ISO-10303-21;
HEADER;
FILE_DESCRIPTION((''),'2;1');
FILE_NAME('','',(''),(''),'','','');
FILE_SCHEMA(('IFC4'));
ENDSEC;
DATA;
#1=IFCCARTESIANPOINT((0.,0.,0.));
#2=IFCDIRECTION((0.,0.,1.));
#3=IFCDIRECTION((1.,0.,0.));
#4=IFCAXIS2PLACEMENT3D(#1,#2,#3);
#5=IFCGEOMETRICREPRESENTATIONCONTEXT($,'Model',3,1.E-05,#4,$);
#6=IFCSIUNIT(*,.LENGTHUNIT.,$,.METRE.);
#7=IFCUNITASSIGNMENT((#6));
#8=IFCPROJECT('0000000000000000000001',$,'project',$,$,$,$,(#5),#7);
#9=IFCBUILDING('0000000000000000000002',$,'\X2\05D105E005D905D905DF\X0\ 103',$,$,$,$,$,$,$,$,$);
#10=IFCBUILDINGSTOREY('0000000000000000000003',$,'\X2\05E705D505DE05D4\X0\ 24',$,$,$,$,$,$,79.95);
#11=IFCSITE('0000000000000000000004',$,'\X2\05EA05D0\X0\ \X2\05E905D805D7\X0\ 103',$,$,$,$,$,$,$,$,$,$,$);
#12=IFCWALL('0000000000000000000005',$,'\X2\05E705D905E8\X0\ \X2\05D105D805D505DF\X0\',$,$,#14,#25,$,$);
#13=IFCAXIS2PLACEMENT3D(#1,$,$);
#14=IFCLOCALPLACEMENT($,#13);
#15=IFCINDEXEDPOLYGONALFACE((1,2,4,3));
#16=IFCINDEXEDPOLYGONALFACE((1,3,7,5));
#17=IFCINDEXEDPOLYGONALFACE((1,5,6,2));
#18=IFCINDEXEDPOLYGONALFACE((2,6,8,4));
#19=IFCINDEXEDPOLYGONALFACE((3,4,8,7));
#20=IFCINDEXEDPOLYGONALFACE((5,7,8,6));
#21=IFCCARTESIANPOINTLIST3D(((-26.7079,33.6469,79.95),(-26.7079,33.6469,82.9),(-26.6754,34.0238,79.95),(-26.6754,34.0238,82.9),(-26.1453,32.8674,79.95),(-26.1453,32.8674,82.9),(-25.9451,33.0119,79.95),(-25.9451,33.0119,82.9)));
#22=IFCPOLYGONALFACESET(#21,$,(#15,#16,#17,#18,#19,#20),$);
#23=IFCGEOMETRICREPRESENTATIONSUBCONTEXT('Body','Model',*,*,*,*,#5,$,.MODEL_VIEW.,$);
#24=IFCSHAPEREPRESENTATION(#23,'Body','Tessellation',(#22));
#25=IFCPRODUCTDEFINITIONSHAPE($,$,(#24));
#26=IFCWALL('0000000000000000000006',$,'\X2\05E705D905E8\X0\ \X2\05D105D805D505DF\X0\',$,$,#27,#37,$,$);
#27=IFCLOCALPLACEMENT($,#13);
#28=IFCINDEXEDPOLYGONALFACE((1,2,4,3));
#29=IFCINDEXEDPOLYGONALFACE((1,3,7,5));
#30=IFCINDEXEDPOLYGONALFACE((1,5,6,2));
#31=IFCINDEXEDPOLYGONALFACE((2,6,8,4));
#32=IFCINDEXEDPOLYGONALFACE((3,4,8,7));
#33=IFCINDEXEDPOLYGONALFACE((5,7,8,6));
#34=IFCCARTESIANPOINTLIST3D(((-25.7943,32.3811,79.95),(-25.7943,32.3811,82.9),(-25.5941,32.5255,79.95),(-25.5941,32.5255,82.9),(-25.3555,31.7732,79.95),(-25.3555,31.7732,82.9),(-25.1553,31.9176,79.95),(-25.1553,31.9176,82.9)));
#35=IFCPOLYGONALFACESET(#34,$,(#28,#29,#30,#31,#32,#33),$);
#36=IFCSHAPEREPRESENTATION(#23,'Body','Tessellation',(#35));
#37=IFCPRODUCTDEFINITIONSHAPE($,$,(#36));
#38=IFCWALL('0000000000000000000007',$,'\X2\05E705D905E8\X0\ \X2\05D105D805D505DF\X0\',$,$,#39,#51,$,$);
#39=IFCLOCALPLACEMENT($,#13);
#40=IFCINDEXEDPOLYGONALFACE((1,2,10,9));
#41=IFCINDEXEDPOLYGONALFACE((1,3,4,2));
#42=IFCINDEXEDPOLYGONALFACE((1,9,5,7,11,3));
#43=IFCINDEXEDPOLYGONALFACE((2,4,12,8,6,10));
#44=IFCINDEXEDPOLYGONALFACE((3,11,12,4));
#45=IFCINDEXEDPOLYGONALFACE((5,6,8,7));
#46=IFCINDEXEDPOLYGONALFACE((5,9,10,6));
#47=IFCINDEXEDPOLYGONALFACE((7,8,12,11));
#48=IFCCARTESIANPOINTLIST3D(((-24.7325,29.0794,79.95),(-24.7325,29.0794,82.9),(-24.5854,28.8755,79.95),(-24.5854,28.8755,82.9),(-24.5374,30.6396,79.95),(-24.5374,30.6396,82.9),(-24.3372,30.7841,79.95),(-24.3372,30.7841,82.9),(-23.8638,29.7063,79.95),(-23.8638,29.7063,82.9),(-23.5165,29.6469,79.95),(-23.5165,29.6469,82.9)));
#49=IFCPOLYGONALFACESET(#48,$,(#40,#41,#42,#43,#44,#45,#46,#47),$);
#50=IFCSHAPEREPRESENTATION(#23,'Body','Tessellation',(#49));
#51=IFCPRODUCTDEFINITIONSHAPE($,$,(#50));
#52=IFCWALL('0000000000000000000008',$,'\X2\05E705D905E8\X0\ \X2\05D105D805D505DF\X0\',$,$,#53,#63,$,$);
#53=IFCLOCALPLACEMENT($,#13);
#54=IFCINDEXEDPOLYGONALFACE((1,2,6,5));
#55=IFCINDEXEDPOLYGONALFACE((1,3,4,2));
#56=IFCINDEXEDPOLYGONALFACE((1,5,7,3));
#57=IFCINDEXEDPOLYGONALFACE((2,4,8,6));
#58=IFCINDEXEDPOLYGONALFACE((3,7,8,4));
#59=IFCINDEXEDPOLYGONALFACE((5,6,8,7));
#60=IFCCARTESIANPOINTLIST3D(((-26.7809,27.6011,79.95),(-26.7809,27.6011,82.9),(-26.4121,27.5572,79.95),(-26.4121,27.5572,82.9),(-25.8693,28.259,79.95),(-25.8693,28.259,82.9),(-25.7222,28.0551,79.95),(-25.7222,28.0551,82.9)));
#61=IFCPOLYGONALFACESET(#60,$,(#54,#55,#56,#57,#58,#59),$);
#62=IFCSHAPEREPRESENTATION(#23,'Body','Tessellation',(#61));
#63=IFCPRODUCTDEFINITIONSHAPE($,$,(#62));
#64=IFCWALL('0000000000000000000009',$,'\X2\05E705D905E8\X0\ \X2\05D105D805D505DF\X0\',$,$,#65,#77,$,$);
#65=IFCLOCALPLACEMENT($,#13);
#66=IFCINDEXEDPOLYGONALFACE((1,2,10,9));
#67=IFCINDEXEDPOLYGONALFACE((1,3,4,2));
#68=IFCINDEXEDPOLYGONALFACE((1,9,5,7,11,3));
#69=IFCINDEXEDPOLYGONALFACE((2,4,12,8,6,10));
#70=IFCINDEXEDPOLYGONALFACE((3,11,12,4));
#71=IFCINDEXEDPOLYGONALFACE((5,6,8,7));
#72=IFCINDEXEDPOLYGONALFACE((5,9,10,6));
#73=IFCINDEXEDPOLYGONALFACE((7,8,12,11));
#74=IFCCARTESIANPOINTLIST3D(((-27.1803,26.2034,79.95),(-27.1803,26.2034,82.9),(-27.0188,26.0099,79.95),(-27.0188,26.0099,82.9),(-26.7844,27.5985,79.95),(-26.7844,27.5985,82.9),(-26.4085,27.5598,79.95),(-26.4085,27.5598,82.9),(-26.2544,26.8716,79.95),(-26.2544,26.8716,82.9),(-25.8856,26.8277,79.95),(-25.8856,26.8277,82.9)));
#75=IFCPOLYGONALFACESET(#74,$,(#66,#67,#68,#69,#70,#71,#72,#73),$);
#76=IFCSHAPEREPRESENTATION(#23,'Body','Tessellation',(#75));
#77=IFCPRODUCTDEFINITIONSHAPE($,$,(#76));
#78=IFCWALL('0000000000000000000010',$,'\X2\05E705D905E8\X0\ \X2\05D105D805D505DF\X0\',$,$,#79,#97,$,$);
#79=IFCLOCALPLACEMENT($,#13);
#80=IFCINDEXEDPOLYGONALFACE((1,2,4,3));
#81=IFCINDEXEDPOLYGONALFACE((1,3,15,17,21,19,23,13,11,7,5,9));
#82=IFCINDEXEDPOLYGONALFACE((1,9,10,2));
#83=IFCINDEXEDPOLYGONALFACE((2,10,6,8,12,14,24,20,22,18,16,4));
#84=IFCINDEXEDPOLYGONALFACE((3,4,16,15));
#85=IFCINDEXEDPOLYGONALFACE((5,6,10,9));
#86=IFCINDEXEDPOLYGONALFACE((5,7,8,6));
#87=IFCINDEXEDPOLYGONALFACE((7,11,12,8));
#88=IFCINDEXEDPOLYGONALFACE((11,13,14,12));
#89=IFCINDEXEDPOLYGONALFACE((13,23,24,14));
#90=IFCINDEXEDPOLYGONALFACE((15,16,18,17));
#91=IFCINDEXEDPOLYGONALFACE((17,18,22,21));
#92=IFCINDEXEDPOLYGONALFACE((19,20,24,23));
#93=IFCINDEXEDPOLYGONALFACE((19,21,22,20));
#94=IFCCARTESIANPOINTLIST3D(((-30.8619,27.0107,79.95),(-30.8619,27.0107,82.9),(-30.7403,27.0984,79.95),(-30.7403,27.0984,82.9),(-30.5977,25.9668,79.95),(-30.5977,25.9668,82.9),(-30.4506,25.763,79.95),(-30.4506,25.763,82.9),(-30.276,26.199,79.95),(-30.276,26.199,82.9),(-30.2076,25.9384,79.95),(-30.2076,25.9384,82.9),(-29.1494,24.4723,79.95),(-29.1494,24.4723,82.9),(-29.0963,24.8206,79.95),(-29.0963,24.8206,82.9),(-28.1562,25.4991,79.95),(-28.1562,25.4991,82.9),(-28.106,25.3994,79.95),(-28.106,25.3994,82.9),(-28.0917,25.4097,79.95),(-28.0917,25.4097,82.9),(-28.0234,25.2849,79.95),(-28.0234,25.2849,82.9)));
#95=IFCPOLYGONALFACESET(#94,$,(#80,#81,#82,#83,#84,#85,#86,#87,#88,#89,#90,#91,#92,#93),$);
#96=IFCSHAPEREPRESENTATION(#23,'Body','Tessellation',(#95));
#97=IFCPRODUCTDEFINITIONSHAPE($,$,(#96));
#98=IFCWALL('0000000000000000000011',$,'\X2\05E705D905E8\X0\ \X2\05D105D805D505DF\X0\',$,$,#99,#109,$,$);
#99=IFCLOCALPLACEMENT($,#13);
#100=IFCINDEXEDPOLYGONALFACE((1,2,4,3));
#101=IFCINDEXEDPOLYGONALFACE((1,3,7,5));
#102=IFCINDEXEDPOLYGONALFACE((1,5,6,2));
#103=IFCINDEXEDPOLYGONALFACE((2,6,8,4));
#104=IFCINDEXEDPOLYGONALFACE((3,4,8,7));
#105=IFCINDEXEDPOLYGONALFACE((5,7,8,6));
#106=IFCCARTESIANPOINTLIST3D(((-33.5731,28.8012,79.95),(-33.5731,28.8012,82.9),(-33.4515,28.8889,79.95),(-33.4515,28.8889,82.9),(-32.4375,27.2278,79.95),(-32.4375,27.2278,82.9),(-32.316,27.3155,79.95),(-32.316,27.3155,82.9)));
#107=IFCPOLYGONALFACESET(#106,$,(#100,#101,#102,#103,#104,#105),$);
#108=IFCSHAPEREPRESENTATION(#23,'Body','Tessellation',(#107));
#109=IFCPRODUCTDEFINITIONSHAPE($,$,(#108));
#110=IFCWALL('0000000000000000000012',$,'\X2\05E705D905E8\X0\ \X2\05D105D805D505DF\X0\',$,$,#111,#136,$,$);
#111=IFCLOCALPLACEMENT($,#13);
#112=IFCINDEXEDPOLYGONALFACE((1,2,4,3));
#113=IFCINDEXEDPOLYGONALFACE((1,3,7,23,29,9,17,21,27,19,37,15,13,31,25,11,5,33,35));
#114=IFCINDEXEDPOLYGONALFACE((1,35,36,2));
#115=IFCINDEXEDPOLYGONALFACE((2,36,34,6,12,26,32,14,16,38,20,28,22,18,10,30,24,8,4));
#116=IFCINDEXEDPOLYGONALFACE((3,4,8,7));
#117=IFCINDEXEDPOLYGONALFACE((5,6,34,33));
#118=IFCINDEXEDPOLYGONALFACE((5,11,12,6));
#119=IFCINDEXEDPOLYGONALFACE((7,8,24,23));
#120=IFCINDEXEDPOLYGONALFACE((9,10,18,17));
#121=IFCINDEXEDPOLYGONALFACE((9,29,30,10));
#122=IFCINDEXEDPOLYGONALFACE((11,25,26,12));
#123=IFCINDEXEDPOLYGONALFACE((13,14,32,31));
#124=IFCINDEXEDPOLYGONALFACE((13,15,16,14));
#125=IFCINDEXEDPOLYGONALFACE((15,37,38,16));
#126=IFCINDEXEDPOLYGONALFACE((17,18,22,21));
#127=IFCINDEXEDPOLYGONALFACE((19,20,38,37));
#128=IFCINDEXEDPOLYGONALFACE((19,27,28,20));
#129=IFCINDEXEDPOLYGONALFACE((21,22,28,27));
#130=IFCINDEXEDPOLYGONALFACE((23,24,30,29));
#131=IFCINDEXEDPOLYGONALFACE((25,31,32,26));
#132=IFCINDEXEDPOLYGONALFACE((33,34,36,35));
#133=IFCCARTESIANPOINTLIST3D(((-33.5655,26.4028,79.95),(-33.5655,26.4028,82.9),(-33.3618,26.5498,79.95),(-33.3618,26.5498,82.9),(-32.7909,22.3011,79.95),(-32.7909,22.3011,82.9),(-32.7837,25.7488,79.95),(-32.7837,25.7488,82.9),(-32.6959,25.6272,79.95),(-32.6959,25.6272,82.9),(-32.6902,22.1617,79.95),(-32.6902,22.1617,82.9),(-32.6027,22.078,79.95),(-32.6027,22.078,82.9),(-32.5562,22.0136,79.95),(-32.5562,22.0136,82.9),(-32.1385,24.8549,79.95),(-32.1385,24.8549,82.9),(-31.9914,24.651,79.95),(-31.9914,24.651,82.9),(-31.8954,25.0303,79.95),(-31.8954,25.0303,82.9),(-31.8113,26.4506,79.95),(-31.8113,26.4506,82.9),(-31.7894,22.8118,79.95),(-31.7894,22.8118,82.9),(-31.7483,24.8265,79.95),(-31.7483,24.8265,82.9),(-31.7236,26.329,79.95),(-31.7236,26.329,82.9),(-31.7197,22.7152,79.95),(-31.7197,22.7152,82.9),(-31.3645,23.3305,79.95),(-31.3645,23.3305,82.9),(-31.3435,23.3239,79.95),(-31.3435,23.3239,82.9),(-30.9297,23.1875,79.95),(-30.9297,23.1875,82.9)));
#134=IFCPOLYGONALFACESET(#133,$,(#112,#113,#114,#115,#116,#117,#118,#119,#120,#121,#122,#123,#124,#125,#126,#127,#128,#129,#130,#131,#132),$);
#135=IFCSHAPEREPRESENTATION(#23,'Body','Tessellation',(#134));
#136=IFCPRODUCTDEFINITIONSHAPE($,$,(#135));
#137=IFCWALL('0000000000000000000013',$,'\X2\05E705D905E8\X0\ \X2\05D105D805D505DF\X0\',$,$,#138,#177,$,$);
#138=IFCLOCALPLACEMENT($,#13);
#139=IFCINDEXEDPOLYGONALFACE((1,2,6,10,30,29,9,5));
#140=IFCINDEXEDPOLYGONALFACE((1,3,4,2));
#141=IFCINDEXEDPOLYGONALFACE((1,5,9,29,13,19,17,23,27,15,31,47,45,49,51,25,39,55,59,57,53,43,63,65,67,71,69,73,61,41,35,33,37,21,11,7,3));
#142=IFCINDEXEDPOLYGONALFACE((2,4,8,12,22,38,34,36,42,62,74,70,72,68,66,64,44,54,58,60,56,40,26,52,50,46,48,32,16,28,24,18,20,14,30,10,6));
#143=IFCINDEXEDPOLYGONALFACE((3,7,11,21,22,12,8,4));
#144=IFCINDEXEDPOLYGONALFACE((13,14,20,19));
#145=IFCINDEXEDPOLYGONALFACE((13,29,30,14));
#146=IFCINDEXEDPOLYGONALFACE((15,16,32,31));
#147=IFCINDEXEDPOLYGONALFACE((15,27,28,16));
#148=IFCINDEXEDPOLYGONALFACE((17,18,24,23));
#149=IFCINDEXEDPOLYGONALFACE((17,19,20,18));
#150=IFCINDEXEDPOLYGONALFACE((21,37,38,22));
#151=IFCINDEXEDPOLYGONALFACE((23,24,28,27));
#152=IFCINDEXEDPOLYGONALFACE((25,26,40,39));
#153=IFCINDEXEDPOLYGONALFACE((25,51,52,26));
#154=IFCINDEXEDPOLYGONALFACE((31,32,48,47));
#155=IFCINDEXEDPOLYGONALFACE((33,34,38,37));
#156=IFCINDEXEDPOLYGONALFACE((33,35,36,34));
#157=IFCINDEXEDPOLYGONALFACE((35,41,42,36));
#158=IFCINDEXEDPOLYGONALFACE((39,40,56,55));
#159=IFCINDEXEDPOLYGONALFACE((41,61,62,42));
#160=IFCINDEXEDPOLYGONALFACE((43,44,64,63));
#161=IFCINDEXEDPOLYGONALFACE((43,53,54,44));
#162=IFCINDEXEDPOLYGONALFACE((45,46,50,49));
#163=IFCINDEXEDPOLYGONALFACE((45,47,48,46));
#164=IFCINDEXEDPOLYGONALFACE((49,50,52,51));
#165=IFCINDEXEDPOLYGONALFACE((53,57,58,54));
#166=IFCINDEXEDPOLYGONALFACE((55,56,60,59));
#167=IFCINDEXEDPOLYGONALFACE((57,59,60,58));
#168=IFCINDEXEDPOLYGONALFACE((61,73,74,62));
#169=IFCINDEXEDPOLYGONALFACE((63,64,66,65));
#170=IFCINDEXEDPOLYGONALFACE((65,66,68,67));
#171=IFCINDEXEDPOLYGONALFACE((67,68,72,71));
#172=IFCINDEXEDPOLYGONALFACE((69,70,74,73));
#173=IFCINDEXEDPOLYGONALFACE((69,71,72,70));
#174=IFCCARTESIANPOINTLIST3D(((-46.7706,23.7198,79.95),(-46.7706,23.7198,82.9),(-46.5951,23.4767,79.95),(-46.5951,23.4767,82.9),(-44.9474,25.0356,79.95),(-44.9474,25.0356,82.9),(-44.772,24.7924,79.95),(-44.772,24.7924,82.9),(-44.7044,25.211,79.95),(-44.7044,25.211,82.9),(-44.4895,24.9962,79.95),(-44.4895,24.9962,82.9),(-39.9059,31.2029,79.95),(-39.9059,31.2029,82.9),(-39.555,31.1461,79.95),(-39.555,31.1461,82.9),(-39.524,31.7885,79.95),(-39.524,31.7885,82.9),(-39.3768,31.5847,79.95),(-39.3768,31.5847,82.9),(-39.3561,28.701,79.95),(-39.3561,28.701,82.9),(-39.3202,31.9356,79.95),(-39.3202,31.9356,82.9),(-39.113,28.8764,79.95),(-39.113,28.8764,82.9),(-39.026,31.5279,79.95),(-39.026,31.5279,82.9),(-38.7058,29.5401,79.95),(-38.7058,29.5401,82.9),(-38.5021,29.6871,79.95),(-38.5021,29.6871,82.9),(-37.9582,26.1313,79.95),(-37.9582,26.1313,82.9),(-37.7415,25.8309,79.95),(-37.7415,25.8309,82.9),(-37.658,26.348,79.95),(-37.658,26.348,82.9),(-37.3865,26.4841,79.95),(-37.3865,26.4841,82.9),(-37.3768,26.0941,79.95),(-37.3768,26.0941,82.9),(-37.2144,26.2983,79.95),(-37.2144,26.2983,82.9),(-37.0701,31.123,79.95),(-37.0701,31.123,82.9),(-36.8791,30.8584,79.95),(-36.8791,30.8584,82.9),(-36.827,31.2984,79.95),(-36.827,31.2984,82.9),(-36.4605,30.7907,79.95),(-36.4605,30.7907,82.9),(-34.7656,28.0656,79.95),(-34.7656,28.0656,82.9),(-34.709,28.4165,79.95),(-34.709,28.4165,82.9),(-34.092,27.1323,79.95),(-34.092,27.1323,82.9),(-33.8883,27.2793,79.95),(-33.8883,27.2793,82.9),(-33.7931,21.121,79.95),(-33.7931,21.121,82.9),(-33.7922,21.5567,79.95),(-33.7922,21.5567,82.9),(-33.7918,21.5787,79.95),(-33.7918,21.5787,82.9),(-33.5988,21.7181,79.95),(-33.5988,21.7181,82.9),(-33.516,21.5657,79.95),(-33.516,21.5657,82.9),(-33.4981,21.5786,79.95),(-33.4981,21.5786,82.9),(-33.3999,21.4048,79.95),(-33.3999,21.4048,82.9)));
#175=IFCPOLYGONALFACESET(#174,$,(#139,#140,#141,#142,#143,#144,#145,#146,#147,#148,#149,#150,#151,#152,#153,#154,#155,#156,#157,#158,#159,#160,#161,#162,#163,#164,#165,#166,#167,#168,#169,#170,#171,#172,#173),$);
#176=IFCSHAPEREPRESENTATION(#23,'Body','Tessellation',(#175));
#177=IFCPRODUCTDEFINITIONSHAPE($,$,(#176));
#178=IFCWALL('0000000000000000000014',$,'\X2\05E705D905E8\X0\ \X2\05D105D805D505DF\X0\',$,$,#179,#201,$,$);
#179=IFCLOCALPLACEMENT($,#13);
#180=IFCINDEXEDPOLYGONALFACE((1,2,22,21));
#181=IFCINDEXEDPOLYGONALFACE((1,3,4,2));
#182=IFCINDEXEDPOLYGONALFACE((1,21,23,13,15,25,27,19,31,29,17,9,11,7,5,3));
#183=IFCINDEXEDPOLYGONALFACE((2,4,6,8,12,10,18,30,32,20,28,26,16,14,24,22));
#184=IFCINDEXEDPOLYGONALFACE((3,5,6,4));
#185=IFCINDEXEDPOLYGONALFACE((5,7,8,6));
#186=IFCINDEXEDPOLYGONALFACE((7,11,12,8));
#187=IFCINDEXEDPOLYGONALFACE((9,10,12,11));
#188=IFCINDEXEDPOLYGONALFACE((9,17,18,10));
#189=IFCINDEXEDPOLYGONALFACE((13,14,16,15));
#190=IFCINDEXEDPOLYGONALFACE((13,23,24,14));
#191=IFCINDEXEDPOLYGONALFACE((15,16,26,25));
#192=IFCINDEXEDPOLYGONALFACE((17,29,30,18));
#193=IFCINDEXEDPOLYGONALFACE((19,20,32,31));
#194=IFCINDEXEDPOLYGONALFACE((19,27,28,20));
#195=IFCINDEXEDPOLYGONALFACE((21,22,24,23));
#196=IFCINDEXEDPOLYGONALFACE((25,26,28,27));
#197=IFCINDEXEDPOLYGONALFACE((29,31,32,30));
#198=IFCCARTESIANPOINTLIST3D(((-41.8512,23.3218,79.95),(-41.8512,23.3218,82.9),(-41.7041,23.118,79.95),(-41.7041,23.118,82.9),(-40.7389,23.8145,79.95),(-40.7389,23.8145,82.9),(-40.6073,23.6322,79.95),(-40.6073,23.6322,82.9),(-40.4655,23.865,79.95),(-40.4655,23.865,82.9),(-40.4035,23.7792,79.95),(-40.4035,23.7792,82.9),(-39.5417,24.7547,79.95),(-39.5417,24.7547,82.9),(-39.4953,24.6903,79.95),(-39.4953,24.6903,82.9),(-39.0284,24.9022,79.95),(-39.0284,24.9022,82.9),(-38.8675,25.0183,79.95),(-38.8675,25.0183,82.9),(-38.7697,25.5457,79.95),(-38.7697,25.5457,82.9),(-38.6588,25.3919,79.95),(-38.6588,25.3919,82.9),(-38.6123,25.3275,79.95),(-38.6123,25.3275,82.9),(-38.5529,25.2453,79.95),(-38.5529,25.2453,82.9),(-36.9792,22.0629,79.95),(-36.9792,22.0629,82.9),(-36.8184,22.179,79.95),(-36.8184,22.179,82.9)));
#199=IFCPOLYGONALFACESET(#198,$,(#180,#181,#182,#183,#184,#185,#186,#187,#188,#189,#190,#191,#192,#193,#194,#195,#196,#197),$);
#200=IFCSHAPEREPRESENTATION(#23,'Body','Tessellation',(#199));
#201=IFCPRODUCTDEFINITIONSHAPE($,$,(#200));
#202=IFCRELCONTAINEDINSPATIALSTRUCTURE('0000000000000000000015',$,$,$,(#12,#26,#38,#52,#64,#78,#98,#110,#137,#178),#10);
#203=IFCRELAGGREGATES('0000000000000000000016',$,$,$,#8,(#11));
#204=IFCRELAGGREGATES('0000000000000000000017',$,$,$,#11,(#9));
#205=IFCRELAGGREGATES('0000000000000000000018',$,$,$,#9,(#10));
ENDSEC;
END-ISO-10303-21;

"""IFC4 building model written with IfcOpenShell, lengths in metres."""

from ifc_helpers import new_model, si_unit, frame, origin_with_axes, context, subcontext, project, spatial, polyline, outline, extrude, element, save


model = new_model("IFC4")

# Units and contexts
model_context = context("Model", 3, precision=1e-05, world=origin_with_axes())
body_context = subcontext(model_context, "Body", "Model", "MODEL_VIEW")
ifc_project = project(units=[si_unit("LENGTHUNIT", "METRE")], contexts=[model_context])

# Site, building, storey
site = spatial("IfcSite", under=ifc_project, Name="תא שטח 103")
building = spatial("IfcBuilding", under=site, Name="בניין 103")
storey = spatial("IfcBuildingStorey", under=building, Name="קומה 24", Elevation=79.95)

# Walls
element("IfcWall", 1, inside=storey, Name="קיר בטון", context=body_context, shape_type="SweptSolid", body=[
    extrude(outline(polyline([(-26.7079, 33.6469), (-26.6754, 34.0238), (-25.9451, 33.0119), (-26.1453, 32.8674), (-26.7079, 33.6469)])), frame((0.0, 0.0, 79.95)), (0.0, 0.0, 1.0), 2.95),
])
element("IfcWall", 2, inside=storey, Name="קיר בטון", context=body_context, shape_type="SweptSolid", body=[
    extrude(outline(polyline([(-25.5941, 32.5255), (-25.1553, 31.9176), (-25.3555, 31.7732), (-25.7943, 32.3811), (-25.5941, 32.5255)])), frame((0.0, 0.0, 79.95)), (0.0, 0.0, 1.0), 2.95),
])
element("IfcWall", 3, inside=storey, Name="קיר בטון", context=body_context, shape_type="SweptSolid", body=[
    extrude(outline(polyline([(-24.5374, 30.6396), (-24.3372, 30.7841), (-23.5165, 29.6469), (-24.5854, 28.8755), (-24.7325, 29.0794), (-23.8638, 29.7063), (-24.5374, 30.6396)])), frame((0.0, 0.0, 79.95)), (0.0, 0.0, 1.0), 2.95),
])
element("IfcWall", 4, inside=storey, Name="קיר בטון", context=body_context, shape_type="SweptSolid", body=[
    extrude(outline(polyline([(-26.4121, 27.5572), (-26.7809, 27.6011), (-25.8693, 28.259), (-25.7222, 28.0551), (-26.4121, 27.5572)])), frame((0.0, 0.0, 79.95)), (0.0, 0.0, 1.0), 2.95),
])
element("IfcWall", 5, inside=storey, Name="קיר בטון", context=body_context, shape_type="SweptSolid", body=[
    extrude(outline(polyline([(-27.0188, 26.0099), (-27.1803, 26.2034), (-26.2544, 26.8716), (-26.7844, 27.5985), (-26.4085, 27.5598), (-25.8856, 26.8277), (-27.0188, 26.0099)])), frame((0.0, 0.0, 79.95)), (0.0, 0.0, 1.0), 2.95),
])
element("IfcWall", 6, inside=storey, Name="קיר בטון", context=body_context, shape_type="SweptSolid", body=[
    extrude(outline(polyline([(-29.1494, 24.4723), (-30.2076, 25.9384), (-30.4506, 25.763), (-30.5977, 25.9668), (-30.276, 26.199), (-30.8619, 27.0107), (-30.7403, 27.0984), (-29.0963, 24.8206), (-28.1562, 25.4991), (-28.0917, 25.4097), (-28.106, 25.3994), (-28.0234, 25.2849), (-29.1494, 24.4723)])), frame((0.0, 0.0, 79.95)), (0.0, 0.0, 1.0), 2.95),
])
element("IfcWall", 7, inside=storey, Name="קיר בטון", context=body_context, shape_type="SweptSolid", body=[
    extrude(outline(polyline([(-32.4375, 27.2278), (-33.5731, 28.8012), (-33.4515, 28.8889), (-32.316, 27.3155), (-32.4375, 27.2278)])), frame((0.0, 0.0, 79.95)), (0.0, 0.0, 1.0), 2.95),
])
element("IfcWall", 8, inside=storey, Name="קיר בטון", context=body_context, shape_type="SweptSolid", body=[
    extrude(outline(polyline([(-31.9914, 24.651), (-30.9297, 23.1875), (-32.5562, 22.0136), (-32.6027, 22.078), (-31.7197, 22.7152), (-31.7894, 22.8118), (-32.6902, 22.1617), (-32.7909, 22.3011), (-31.3645, 23.3305), (-31.3435, 23.3239), (-33.5655, 26.4028), (-33.3618, 26.5498), (-32.7837, 25.7488), (-31.8113, 26.4506), (-31.7236, 26.329), (-32.6959, 25.6272), (-32.1385, 24.8549), (-31.8954, 25.0303), (-31.7483, 24.8265), (-31.9914, 24.651)])), frame((0.0, 0.0, 79.95)), (0.0, 0.0, 1.0), 2.95),
])
element("IfcWall", 9, inside=storey, Name="קיר בטון", context=body_context, shape_type="SweptSolid", body=[
    extrude(outline(polyline([(-37.2144, 26.2983), (-33.7922, 21.5567), (-33.7918, 21.5787), (-33.5988, 21.7181), (-33.4981, 21.5786), (-33.516, 21.5657), (-33.3999, 21.4048), (-33.7931, 21.121), (-37.3768, 26.0941), (-37.7415, 25.8309), (-37.9582, 26.1313), (-37.658, 26.348), (-39.3561, 28.701), (-44.4895, 24.9962), (-44.772, 24.7924), (-46.5951, 23.4767), (-46.7706, 23.7198), (-44.9474, 25.0356), (-44.7044, 25.211), (-38.7058, 29.5401), (-39.9059, 31.2029), (-39.3768, 31.5847), (-39.524, 31.7885), (-39.3202, 31.9356), (-39.026, 31.5279), (-39.555, 31.1461), (-38.5021, 29.6871), (-36.8791, 30.8584), (-37.0701, 31.123), (-36.827, 31.2984), (-36.4605, 30.7907), (-39.113, 28.8764), (-37.3865, 26.4841), (-34.709, 28.4165), (-33.8883, 27.2793), (-34.092, 27.1323), (-34.7656, 28.0656), (-37.2144, 26.2983)])), frame((0.0, 0.0, 79.95)), (0.0, 0.0, 1.0), 2.95),
])
element("IfcWall", 10, inside=storey, Name="קיר בטון", context=body_context, shape_type="SweptSolid", body=[
    extrude(outline(polyline([(-36.9792, 22.0629), (-39.0284, 24.9022), (-40.4655, 23.865), (-40.4035, 23.7792), (-40.6073, 23.6322), (-40.7389, 23.8145), (-41.7041, 23.118), (-41.8512, 23.3218), (-38.7697, 25.5457), (-38.6588, 25.3919), (-39.5417, 24.7547), (-39.4953, 24.6903), (-38.6123, 25.3275), (-38.5529, 25.2453), (-38.8675, 25.0183), (-36.8184, 22.179), (-36.9792, 22.0629)])), frame((0.0, 0.0, 79.95)), (0.0, 0.0, 1.0), 2.95),
])

save(model, "model.ifc")
